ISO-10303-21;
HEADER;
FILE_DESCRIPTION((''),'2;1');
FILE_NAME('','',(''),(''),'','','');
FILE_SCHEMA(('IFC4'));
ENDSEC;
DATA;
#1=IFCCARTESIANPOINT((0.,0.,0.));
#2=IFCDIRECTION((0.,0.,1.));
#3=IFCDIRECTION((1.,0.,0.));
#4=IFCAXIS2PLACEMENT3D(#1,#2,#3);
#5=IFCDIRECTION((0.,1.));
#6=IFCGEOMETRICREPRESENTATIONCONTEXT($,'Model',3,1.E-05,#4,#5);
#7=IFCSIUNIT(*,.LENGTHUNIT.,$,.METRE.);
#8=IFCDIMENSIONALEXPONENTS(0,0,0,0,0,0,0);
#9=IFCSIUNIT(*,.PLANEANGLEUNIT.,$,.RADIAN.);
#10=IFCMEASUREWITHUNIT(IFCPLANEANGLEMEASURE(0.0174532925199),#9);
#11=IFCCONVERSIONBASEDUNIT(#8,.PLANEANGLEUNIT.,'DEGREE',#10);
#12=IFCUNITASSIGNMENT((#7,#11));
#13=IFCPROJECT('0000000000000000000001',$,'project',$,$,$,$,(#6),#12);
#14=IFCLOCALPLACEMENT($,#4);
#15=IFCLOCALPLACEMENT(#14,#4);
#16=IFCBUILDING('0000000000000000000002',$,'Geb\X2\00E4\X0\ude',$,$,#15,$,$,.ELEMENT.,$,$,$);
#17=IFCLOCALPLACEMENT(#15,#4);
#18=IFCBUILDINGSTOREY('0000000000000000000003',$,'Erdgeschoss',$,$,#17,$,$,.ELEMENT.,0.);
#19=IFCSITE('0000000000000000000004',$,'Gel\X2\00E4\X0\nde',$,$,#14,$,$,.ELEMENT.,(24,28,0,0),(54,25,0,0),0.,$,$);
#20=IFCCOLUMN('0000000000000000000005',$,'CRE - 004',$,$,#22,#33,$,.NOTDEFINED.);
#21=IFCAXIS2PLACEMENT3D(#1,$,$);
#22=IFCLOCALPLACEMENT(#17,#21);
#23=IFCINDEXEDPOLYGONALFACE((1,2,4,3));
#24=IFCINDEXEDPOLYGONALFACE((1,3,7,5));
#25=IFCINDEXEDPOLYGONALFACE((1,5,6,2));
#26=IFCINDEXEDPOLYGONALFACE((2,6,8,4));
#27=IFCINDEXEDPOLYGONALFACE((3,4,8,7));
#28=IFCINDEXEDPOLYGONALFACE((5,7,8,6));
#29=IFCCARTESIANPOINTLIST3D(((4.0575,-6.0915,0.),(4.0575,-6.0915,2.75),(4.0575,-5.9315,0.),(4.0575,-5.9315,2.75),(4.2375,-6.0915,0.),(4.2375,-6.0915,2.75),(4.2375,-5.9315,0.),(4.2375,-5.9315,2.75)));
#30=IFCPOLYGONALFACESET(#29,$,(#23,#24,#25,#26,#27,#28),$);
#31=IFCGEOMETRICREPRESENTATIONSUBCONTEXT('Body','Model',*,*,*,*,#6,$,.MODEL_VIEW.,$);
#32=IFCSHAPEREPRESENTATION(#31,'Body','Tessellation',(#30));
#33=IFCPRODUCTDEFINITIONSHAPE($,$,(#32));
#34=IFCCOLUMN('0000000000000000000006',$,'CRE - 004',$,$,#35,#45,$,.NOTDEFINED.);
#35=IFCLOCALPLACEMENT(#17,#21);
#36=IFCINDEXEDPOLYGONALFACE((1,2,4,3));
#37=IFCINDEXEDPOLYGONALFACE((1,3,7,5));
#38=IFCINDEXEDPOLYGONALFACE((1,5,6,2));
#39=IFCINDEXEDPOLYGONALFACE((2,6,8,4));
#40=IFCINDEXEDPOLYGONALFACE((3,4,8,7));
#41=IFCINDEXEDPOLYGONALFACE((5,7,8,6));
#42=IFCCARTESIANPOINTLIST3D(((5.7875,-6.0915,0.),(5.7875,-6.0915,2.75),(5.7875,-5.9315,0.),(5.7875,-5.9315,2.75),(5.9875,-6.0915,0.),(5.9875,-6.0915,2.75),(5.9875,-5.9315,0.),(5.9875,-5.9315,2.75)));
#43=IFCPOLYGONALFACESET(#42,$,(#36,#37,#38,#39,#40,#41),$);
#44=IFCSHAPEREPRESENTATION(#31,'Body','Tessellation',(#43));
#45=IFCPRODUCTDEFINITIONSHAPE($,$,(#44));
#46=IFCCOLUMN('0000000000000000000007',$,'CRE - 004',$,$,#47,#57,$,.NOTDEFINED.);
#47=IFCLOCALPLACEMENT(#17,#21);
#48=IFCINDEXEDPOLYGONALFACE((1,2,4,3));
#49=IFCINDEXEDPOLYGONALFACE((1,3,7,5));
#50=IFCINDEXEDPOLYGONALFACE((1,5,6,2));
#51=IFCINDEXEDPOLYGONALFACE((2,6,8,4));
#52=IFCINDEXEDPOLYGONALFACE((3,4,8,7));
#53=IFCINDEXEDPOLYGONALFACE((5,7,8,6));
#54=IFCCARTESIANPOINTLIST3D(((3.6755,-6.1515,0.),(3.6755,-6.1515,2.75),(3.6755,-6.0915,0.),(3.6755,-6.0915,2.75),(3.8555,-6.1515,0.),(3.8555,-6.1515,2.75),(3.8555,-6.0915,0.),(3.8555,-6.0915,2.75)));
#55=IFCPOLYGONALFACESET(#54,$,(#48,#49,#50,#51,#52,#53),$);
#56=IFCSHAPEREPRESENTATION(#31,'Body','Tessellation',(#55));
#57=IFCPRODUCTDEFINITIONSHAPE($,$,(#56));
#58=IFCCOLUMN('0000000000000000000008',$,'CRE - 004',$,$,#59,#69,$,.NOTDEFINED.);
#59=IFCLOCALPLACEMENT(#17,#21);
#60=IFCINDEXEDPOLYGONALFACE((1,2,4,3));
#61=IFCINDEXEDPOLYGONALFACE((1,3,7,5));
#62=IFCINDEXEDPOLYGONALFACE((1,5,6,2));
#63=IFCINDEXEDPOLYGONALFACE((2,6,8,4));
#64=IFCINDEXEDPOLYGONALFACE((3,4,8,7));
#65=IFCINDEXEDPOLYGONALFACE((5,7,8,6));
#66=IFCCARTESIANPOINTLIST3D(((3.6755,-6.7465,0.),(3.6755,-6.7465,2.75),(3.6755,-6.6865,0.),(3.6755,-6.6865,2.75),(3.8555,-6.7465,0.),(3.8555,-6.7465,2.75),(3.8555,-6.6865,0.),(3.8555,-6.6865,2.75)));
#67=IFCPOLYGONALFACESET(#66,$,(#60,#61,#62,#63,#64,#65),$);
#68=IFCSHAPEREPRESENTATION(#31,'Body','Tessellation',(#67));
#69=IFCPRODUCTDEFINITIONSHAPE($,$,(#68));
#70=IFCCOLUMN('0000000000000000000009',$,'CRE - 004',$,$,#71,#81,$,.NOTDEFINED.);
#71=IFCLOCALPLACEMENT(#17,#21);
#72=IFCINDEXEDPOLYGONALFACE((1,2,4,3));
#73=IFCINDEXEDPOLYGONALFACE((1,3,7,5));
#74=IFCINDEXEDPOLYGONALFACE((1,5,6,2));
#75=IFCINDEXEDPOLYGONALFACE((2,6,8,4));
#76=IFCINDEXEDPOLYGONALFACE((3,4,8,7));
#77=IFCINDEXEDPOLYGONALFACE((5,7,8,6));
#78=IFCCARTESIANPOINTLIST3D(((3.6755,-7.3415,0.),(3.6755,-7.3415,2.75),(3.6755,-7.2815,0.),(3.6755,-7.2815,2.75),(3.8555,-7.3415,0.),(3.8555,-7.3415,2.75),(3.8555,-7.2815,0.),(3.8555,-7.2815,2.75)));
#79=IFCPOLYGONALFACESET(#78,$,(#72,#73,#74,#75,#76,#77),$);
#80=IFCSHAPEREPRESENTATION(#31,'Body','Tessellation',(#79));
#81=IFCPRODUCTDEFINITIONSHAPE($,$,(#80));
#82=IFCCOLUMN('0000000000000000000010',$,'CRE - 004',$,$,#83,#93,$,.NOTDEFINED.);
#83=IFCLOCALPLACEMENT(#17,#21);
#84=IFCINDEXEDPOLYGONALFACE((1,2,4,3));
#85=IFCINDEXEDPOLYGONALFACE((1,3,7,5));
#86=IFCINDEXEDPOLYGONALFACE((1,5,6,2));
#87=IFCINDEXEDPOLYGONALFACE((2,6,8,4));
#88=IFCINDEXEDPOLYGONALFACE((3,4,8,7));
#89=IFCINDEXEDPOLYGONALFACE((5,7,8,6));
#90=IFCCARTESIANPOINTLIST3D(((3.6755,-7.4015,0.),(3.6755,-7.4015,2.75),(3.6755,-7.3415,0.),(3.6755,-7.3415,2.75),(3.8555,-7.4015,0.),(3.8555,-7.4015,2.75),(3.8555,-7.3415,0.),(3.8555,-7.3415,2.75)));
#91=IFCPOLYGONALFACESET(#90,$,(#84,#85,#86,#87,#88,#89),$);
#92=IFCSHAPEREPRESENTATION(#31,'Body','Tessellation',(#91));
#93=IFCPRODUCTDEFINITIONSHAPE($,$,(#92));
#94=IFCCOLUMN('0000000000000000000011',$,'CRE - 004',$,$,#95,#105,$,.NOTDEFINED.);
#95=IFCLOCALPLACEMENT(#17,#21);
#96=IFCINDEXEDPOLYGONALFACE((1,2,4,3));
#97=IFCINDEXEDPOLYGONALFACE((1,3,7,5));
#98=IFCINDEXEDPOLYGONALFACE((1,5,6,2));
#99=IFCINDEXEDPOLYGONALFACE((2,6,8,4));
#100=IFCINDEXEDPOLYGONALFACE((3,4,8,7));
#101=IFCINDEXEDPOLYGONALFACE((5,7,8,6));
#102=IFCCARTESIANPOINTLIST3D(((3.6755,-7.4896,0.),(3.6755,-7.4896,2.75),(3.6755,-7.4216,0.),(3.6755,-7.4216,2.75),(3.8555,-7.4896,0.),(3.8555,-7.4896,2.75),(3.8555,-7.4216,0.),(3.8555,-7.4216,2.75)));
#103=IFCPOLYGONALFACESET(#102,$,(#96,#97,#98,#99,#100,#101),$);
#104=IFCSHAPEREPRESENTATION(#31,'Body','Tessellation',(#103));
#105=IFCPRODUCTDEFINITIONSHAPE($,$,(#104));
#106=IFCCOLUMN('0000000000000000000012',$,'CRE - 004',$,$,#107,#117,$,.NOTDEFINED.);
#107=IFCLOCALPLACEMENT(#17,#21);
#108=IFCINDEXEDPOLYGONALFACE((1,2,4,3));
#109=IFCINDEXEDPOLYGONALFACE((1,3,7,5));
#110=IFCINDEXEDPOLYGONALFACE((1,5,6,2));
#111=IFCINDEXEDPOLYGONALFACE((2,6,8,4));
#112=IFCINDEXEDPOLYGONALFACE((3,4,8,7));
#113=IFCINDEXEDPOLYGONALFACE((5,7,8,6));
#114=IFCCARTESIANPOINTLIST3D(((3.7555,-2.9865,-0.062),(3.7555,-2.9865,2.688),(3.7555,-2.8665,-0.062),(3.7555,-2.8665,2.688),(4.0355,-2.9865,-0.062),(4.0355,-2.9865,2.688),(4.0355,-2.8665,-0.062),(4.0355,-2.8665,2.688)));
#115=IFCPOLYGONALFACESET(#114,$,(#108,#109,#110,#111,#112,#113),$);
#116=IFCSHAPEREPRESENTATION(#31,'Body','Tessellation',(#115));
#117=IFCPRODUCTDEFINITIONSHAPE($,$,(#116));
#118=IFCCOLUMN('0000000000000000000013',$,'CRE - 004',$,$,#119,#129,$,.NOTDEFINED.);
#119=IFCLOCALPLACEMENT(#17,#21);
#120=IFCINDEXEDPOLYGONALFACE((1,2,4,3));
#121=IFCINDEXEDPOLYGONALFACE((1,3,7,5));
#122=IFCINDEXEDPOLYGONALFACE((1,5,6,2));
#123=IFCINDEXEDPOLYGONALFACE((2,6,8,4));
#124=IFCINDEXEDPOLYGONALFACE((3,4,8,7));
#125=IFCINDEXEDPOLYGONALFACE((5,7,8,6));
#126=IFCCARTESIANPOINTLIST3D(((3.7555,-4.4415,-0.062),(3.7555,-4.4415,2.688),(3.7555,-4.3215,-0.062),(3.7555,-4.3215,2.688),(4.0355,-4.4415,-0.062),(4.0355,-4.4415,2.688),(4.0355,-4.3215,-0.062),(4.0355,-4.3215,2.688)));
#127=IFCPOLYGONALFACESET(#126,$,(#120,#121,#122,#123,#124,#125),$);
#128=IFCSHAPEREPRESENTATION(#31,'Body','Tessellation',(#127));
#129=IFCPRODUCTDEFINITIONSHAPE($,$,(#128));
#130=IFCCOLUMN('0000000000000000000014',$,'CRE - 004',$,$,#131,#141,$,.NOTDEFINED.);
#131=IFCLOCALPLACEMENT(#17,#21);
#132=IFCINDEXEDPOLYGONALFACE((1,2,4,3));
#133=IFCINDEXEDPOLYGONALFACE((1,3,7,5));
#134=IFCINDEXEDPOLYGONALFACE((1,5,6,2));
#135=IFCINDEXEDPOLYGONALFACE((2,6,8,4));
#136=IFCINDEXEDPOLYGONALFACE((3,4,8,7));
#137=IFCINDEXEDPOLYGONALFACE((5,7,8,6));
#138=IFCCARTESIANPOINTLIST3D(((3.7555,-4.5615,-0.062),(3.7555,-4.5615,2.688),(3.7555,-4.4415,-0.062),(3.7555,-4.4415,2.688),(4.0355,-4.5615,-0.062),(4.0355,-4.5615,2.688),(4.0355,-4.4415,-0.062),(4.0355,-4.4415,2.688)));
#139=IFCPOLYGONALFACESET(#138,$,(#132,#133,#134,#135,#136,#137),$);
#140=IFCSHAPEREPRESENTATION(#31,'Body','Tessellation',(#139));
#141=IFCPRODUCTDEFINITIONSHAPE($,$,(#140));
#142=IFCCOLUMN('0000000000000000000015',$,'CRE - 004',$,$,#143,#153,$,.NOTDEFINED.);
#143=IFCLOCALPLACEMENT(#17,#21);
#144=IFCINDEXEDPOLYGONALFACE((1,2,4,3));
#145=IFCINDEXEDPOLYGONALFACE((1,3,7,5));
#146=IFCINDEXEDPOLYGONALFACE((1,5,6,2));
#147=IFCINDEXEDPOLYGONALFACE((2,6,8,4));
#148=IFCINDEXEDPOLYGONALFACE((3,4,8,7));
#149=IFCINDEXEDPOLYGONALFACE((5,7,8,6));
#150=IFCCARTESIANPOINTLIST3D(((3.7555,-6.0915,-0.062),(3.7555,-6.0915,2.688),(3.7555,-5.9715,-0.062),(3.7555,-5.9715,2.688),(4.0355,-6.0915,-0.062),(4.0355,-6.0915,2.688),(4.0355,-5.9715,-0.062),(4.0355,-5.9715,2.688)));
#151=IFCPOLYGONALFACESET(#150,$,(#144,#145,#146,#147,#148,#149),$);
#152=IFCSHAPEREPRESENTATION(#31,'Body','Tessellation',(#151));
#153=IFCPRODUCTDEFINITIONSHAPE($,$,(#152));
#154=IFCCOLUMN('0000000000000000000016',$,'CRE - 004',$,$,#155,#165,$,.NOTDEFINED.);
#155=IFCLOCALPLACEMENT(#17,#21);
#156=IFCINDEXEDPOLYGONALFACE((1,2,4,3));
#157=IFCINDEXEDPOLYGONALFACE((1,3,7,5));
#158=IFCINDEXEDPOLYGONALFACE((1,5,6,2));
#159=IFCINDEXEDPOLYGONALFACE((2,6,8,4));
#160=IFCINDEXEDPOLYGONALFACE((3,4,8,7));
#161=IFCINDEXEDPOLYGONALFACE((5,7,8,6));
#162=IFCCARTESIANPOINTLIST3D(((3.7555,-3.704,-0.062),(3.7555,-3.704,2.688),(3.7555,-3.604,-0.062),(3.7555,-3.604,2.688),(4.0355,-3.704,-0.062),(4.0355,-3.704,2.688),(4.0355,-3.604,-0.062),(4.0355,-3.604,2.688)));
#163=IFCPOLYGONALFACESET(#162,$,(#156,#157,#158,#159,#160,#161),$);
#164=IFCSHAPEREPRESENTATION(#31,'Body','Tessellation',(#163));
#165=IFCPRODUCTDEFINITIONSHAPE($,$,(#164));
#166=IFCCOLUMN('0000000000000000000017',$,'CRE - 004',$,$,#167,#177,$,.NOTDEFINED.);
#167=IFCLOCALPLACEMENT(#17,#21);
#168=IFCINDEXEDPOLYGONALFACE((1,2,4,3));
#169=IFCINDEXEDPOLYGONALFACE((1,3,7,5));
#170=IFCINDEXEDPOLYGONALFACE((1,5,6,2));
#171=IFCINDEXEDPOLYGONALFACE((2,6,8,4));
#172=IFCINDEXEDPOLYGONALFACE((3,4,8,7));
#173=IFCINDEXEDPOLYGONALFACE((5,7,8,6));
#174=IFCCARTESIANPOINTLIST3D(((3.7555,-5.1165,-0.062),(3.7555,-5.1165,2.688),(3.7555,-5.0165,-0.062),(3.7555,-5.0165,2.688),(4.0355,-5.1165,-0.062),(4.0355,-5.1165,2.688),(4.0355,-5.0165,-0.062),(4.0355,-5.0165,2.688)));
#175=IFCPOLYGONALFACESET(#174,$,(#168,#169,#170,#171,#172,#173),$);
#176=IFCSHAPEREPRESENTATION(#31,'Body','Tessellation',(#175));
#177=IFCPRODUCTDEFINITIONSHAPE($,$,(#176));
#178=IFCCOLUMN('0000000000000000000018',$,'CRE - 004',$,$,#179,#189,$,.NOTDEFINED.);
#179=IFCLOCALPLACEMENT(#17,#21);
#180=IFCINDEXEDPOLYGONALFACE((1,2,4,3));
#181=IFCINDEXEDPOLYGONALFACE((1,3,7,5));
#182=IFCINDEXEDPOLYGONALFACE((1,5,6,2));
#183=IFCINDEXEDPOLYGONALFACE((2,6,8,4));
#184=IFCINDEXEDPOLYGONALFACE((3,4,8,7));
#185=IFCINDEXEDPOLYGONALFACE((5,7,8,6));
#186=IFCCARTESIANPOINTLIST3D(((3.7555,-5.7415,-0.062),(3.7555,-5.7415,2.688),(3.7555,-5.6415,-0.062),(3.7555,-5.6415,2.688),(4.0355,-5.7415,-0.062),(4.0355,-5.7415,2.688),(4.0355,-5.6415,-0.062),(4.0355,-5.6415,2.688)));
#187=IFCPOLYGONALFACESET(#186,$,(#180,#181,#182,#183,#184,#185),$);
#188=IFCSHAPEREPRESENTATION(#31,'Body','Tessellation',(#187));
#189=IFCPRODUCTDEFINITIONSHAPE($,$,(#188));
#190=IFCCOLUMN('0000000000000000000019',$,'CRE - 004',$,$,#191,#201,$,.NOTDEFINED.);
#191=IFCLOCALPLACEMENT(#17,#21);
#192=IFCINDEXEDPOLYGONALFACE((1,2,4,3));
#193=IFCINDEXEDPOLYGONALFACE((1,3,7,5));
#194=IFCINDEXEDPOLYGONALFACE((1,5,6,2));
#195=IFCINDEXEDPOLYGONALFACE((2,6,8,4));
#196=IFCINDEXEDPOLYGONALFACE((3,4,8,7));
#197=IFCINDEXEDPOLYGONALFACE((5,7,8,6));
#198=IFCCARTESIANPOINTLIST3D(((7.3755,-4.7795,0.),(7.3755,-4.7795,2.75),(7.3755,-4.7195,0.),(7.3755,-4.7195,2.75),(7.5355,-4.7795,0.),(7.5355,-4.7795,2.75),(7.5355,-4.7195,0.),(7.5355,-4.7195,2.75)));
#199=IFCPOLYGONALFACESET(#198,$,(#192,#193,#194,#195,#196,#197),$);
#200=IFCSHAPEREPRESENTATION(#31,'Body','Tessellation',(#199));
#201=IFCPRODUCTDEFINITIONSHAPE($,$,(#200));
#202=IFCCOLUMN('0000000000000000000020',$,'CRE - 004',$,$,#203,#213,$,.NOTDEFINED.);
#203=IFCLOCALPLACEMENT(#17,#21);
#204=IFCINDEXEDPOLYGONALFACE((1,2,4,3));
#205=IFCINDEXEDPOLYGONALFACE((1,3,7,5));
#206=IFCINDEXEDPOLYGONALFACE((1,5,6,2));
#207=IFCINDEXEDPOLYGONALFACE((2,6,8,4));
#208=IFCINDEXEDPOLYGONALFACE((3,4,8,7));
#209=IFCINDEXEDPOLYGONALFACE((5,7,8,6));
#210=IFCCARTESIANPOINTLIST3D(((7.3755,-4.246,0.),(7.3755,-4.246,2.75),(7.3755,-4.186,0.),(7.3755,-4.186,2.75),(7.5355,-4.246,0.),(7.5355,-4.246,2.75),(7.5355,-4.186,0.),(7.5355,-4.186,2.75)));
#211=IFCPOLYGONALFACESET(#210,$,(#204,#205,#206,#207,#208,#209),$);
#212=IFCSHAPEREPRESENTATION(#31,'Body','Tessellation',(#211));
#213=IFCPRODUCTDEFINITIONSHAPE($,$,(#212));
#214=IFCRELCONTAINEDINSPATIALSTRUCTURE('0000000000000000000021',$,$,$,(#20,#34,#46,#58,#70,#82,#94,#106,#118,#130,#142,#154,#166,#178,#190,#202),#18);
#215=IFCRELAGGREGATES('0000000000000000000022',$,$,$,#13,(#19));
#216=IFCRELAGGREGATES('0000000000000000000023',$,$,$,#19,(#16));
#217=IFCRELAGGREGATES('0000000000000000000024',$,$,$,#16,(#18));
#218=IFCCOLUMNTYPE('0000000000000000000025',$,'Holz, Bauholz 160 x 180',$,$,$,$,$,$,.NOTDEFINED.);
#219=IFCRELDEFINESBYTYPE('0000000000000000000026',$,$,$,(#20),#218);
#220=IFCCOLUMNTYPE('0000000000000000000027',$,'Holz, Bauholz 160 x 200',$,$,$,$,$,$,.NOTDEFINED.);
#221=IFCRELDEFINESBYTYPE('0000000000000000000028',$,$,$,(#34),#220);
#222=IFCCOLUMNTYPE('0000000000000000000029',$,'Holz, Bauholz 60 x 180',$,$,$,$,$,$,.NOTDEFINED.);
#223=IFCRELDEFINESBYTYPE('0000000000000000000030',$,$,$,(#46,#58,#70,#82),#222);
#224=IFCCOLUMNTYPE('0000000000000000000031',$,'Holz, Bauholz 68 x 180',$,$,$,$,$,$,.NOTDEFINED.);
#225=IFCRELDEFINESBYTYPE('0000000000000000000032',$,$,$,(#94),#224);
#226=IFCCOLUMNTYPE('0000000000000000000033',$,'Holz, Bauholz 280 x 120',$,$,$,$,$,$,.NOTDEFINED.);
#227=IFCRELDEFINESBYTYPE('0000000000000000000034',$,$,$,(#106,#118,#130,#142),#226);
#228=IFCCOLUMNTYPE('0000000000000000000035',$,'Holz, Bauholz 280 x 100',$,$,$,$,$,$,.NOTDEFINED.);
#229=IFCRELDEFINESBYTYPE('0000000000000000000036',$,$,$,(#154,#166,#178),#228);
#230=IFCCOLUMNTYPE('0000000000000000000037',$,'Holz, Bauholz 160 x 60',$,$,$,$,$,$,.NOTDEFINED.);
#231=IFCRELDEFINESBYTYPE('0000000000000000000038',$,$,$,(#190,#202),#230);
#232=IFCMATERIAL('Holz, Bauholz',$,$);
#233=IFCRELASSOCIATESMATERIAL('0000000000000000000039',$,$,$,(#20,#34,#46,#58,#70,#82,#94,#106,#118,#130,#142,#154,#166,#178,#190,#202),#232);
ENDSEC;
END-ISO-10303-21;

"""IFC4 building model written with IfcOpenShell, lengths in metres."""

from ifc_helpers import new_model, entity, si_unit, converted_unit, direction, frame, origin_with_axes, origin_2d_with_axis, place, context, subcontext, project, spatial, rectangle, extrude, material, type_object, element, save


model = new_model("IFC4")

# Units and contexts
model_context = context("Model", 3, precision=1e-05, world=origin_with_axes(), true_north=direction((0.0, 1.0)))
body_context = subcontext(model_context, "Body", "Model", "MODEL_VIEW")
ifc_project = project(units=[si_unit("LENGTHUNIT", "METRE"), converted_unit("PLANEANGLEUNIT", "DEGREE", entity("IfcPlaneAngleMeasure", 0.0174532925199), si_unit("PLANEANGLEUNIT", "RADIAN"), dimensions=[0, 0, 0, 0, 0, 0, 0])], contexts=[model_context])

# Site, building, storey
site_placement = place(None, origin_with_axes())
site = spatial("IfcSite", under=ifc_project, at=site_placement, Name="Gelände", CompositionType="ELEMENT", RefLatitude=(24, 28, 0, 0), RefLongitude=(54, 25, 0, 0), RefElevation=0.0)
building_placement = place(site_placement, origin_with_axes())
building = spatial("IfcBuilding", under=site, at=building_placement, Name="Gebäude", CompositionType="ELEMENT")
storey_placement = place(building_placement, origin_with_axes())
storey = spatial("IfcBuildingStorey", under=building, at=storey_placement, Name="Erdgeschoss", CompositionType="ELEMENT", Elevation=0.0)

# Columns
ifc_material_1 = material(Name="Holz, Bauholz")
column_type_1 = type_object("IfcColumnType", Name="Holz, Bauholz 160 x 180", PredefinedType="NOTDEFINED")
column_1_placement = place(storey_placement, frame((4.1475, -6.0115, 0.0), z_axis=(0.0, 0.0, 1.0), x_axis=(1.0, 0.0, 0.0)))
element("IfcColumn", 1, at=column_1_placement, inside=storey, type_object=column_type_1, material=ifc_material_1, Name="CRE - 004", PredefinedType="NOTDEFINED", context=body_context, shape_type="SweptSolid", body=[
    extrude(rectangle(XDim=0.16, YDim=0.18, at=origin_2d_with_axis()), frame((0.0, 0.0, 0.0), z_axis=(0.0, 0.0, 1.0), x_axis=(0.0, 1.0, 0.0)), (0.0, 0.0, 1.0), 2.75),
])
column_type_2 = type_object("IfcColumnType", Name="Holz, Bauholz 160 x 200", PredefinedType="NOTDEFINED")
column_2_placement = place(storey_placement, frame((5.8875, -6.0115, 0.0), z_axis=(0.0, 0.0, 1.0), x_axis=(1.0, 0.0, 0.0)))
element("IfcColumn", 2, at=column_2_placement, inside=storey, type_object=column_type_2, material=ifc_material_1, Name="CRE - 004", PredefinedType="NOTDEFINED", context=body_context, shape_type="SweptSolid", body=[
    extrude(rectangle(XDim=0.16, YDim=0.2, at=origin_2d_with_axis()), frame((0.0, 0.0, 0.0), z_axis=(0.0, 0.0, 1.0), x_axis=(0.0, 1.0, 0.0)), (0.0, 0.0, 1.0), 2.75),
])
column_type_3 = type_object("IfcColumnType", Name="Holz, Bauholz 60 x 180", PredefinedType="NOTDEFINED")
for number, where, z_axis, x_axis, name in (
    (3, (3.7655, -6.1215, 0.0), (0.0, 0.0, 1.0), (1.0, 0.0, 0.0), "CRE - 004"),
    (4, (3.7655, -6.7165, 0.0), (0.0, 0.0, 1.0), (1.0, 0.0, 0.0), "CRE - 004"),
    (5, (3.7655, -7.3115, 0.0), (0.0, 0.0, 1.0), (1.0, 0.0, 0.0), "CRE - 004"),
    (6, (3.7655, -7.3715, 0.0), (0.0, 0.0, 1.0), (1.0, 0.0, 0.0), "CRE - 004"),
):
    element("IfcColumn", number, at=place(storey_placement, frame(where, z_axis=z_axis, x_axis=x_axis)), inside=storey, type_object=column_type_3, material=ifc_material_1, Name=name, PredefinedType="NOTDEFINED", context=body_context, shape_type="SweptSolid", body=[
        extrude(rectangle(XDim=0.06, YDim=0.18, at=origin_2d_with_axis()), frame((0.0, 0.0, 0.0), z_axis=(0.0, 0.0, 1.0), x_axis=(0.0, 1.0, 0.0)), (0.0, 0.0, 1.0), 2.75),
    ])
column_type_4 = type_object("IfcColumnType", Name="Holz, Bauholz 68 x 180", PredefinedType="NOTDEFINED")
column_3_placement = place(storey_placement, frame((3.7655, -7.4556, 0.0), z_axis=(0.0, 0.0, 1.0), x_axis=(1.0, 0.0, 0.0)))
element("IfcColumn", 7, at=column_3_placement, inside=storey, type_object=column_type_4, material=ifc_material_1, Name="CRE - 004", PredefinedType="NOTDEFINED", context=body_context, shape_type="SweptSolid", body=[
    extrude(rectangle(XDim=0.068, YDim=0.18, at=origin_2d_with_axis()), frame((0.0, 0.0, 0.0), z_axis=(0.0, 0.0, 1.0), x_axis=(0.0, 1.0, 0.0)), (0.0, 0.0, 1.0), 2.75),
])
column_type_5 = type_object("IfcColumnType", Name="Holz, Bauholz 280 x 120", PredefinedType="NOTDEFINED")
for number, where, z_axis, x_axis, name in (
    (8, (3.8955, -2.9265, -0.062), (0.0, 0.0, 1.0), (0.0, 1.0, 0.0), "CRE - 004"),
    (9, (3.8955, -4.3815, -0.062), (0.0, 0.0, 1.0), (0.0, 1.0, 0.0), "CRE - 004"),
    (10, (3.8955, -4.5015, -0.062), (0.0, 0.0, 1.0), (0.0, 1.0, 0.0), "CRE - 004"),
    (11, (3.8955, -6.0315, -0.062), (0.0, 0.0, 1.0), (0.0, 1.0, 0.0), "CRE - 004"),
):
    element("IfcColumn", number, at=place(storey_placement, frame(where, z_axis=z_axis, x_axis=x_axis)), inside=storey, type_object=column_type_5, material=ifc_material_1, Name=name, PredefinedType="NOTDEFINED", context=body_context, shape_type="SweptSolid", body=[
        extrude(rectangle(XDim=0.28, YDim=0.12, at=origin_2d_with_axis()), frame((0.0, 0.0, 0.0), z_axis=(0.0, 0.0, 1.0), x_axis=(0.0, 1.0, 0.0)), (0.0, 0.0, 1.0), 2.75),
    ])
column_type_6 = type_object("IfcColumnType", Name="Holz, Bauholz 280 x 100", PredefinedType="NOTDEFINED")
for number, where, z_axis, x_axis, name in (
    (12, (3.8955, -3.654, -0.062), (0.0, 0.0, 1.0), (0.0, 1.0, 0.0), "CRE - 004"),
    (13, (3.8955, -5.0665, -0.062), (0.0, 0.0, 1.0), (0.0, 1.0, 0.0), "CRE - 004"),
    (14, (3.8955, -5.6915, -0.062), (0.0, 0.0, 1.0), (0.0, 1.0, 0.0), "CRE - 004"),
):
    element("IfcColumn", number, at=place(storey_placement, frame(where, z_axis=z_axis, x_axis=x_axis)), inside=storey, type_object=column_type_6, material=ifc_material_1, Name=name, PredefinedType="NOTDEFINED", context=body_context, shape_type="SweptSolid", body=[
        extrude(rectangle(XDim=0.28, YDim=0.1, at=origin_2d_with_axis()), frame((0.0, 0.0, 0.0), z_axis=(0.0, 0.0, 1.0), x_axis=(0.0, 1.0, 0.0)), (0.0, 0.0, 1.0), 2.75),
    ])
column_type_7 = type_object("IfcColumnType", Name="Holz, Bauholz 160 x 60", PredefinedType="NOTDEFINED")
for number, where, z_axis, x_axis, name in (
    (15, (7.4555, -4.7495, 0.0), (0.0, 0.0, 1.0), (0.0, -1.0, 0.0), "CRE - 004"),
    (16, (7.4555, -4.216, 0.0), (0.0, 0.0, 1.0), (0.0, -1.0, 0.0), "CRE - 004"),
):
    element("IfcColumn", number, at=place(storey_placement, frame(where, z_axis=z_axis, x_axis=x_axis)), inside=storey, type_object=column_type_7, material=ifc_material_1, Name=name, PredefinedType="NOTDEFINED", context=body_context, shape_type="SweptSolid", body=[
        extrude(rectangle(XDim=0.16, YDim=0.06, at=origin_2d_with_axis()), frame((0.0, 0.0, 0.0), z_axis=(0.0, 0.0, 1.0), x_axis=(0.0, 1.0, 0.0)), (0.0, 0.0, 1.0), 2.75),
    ])

save(model, "model.ifc")
